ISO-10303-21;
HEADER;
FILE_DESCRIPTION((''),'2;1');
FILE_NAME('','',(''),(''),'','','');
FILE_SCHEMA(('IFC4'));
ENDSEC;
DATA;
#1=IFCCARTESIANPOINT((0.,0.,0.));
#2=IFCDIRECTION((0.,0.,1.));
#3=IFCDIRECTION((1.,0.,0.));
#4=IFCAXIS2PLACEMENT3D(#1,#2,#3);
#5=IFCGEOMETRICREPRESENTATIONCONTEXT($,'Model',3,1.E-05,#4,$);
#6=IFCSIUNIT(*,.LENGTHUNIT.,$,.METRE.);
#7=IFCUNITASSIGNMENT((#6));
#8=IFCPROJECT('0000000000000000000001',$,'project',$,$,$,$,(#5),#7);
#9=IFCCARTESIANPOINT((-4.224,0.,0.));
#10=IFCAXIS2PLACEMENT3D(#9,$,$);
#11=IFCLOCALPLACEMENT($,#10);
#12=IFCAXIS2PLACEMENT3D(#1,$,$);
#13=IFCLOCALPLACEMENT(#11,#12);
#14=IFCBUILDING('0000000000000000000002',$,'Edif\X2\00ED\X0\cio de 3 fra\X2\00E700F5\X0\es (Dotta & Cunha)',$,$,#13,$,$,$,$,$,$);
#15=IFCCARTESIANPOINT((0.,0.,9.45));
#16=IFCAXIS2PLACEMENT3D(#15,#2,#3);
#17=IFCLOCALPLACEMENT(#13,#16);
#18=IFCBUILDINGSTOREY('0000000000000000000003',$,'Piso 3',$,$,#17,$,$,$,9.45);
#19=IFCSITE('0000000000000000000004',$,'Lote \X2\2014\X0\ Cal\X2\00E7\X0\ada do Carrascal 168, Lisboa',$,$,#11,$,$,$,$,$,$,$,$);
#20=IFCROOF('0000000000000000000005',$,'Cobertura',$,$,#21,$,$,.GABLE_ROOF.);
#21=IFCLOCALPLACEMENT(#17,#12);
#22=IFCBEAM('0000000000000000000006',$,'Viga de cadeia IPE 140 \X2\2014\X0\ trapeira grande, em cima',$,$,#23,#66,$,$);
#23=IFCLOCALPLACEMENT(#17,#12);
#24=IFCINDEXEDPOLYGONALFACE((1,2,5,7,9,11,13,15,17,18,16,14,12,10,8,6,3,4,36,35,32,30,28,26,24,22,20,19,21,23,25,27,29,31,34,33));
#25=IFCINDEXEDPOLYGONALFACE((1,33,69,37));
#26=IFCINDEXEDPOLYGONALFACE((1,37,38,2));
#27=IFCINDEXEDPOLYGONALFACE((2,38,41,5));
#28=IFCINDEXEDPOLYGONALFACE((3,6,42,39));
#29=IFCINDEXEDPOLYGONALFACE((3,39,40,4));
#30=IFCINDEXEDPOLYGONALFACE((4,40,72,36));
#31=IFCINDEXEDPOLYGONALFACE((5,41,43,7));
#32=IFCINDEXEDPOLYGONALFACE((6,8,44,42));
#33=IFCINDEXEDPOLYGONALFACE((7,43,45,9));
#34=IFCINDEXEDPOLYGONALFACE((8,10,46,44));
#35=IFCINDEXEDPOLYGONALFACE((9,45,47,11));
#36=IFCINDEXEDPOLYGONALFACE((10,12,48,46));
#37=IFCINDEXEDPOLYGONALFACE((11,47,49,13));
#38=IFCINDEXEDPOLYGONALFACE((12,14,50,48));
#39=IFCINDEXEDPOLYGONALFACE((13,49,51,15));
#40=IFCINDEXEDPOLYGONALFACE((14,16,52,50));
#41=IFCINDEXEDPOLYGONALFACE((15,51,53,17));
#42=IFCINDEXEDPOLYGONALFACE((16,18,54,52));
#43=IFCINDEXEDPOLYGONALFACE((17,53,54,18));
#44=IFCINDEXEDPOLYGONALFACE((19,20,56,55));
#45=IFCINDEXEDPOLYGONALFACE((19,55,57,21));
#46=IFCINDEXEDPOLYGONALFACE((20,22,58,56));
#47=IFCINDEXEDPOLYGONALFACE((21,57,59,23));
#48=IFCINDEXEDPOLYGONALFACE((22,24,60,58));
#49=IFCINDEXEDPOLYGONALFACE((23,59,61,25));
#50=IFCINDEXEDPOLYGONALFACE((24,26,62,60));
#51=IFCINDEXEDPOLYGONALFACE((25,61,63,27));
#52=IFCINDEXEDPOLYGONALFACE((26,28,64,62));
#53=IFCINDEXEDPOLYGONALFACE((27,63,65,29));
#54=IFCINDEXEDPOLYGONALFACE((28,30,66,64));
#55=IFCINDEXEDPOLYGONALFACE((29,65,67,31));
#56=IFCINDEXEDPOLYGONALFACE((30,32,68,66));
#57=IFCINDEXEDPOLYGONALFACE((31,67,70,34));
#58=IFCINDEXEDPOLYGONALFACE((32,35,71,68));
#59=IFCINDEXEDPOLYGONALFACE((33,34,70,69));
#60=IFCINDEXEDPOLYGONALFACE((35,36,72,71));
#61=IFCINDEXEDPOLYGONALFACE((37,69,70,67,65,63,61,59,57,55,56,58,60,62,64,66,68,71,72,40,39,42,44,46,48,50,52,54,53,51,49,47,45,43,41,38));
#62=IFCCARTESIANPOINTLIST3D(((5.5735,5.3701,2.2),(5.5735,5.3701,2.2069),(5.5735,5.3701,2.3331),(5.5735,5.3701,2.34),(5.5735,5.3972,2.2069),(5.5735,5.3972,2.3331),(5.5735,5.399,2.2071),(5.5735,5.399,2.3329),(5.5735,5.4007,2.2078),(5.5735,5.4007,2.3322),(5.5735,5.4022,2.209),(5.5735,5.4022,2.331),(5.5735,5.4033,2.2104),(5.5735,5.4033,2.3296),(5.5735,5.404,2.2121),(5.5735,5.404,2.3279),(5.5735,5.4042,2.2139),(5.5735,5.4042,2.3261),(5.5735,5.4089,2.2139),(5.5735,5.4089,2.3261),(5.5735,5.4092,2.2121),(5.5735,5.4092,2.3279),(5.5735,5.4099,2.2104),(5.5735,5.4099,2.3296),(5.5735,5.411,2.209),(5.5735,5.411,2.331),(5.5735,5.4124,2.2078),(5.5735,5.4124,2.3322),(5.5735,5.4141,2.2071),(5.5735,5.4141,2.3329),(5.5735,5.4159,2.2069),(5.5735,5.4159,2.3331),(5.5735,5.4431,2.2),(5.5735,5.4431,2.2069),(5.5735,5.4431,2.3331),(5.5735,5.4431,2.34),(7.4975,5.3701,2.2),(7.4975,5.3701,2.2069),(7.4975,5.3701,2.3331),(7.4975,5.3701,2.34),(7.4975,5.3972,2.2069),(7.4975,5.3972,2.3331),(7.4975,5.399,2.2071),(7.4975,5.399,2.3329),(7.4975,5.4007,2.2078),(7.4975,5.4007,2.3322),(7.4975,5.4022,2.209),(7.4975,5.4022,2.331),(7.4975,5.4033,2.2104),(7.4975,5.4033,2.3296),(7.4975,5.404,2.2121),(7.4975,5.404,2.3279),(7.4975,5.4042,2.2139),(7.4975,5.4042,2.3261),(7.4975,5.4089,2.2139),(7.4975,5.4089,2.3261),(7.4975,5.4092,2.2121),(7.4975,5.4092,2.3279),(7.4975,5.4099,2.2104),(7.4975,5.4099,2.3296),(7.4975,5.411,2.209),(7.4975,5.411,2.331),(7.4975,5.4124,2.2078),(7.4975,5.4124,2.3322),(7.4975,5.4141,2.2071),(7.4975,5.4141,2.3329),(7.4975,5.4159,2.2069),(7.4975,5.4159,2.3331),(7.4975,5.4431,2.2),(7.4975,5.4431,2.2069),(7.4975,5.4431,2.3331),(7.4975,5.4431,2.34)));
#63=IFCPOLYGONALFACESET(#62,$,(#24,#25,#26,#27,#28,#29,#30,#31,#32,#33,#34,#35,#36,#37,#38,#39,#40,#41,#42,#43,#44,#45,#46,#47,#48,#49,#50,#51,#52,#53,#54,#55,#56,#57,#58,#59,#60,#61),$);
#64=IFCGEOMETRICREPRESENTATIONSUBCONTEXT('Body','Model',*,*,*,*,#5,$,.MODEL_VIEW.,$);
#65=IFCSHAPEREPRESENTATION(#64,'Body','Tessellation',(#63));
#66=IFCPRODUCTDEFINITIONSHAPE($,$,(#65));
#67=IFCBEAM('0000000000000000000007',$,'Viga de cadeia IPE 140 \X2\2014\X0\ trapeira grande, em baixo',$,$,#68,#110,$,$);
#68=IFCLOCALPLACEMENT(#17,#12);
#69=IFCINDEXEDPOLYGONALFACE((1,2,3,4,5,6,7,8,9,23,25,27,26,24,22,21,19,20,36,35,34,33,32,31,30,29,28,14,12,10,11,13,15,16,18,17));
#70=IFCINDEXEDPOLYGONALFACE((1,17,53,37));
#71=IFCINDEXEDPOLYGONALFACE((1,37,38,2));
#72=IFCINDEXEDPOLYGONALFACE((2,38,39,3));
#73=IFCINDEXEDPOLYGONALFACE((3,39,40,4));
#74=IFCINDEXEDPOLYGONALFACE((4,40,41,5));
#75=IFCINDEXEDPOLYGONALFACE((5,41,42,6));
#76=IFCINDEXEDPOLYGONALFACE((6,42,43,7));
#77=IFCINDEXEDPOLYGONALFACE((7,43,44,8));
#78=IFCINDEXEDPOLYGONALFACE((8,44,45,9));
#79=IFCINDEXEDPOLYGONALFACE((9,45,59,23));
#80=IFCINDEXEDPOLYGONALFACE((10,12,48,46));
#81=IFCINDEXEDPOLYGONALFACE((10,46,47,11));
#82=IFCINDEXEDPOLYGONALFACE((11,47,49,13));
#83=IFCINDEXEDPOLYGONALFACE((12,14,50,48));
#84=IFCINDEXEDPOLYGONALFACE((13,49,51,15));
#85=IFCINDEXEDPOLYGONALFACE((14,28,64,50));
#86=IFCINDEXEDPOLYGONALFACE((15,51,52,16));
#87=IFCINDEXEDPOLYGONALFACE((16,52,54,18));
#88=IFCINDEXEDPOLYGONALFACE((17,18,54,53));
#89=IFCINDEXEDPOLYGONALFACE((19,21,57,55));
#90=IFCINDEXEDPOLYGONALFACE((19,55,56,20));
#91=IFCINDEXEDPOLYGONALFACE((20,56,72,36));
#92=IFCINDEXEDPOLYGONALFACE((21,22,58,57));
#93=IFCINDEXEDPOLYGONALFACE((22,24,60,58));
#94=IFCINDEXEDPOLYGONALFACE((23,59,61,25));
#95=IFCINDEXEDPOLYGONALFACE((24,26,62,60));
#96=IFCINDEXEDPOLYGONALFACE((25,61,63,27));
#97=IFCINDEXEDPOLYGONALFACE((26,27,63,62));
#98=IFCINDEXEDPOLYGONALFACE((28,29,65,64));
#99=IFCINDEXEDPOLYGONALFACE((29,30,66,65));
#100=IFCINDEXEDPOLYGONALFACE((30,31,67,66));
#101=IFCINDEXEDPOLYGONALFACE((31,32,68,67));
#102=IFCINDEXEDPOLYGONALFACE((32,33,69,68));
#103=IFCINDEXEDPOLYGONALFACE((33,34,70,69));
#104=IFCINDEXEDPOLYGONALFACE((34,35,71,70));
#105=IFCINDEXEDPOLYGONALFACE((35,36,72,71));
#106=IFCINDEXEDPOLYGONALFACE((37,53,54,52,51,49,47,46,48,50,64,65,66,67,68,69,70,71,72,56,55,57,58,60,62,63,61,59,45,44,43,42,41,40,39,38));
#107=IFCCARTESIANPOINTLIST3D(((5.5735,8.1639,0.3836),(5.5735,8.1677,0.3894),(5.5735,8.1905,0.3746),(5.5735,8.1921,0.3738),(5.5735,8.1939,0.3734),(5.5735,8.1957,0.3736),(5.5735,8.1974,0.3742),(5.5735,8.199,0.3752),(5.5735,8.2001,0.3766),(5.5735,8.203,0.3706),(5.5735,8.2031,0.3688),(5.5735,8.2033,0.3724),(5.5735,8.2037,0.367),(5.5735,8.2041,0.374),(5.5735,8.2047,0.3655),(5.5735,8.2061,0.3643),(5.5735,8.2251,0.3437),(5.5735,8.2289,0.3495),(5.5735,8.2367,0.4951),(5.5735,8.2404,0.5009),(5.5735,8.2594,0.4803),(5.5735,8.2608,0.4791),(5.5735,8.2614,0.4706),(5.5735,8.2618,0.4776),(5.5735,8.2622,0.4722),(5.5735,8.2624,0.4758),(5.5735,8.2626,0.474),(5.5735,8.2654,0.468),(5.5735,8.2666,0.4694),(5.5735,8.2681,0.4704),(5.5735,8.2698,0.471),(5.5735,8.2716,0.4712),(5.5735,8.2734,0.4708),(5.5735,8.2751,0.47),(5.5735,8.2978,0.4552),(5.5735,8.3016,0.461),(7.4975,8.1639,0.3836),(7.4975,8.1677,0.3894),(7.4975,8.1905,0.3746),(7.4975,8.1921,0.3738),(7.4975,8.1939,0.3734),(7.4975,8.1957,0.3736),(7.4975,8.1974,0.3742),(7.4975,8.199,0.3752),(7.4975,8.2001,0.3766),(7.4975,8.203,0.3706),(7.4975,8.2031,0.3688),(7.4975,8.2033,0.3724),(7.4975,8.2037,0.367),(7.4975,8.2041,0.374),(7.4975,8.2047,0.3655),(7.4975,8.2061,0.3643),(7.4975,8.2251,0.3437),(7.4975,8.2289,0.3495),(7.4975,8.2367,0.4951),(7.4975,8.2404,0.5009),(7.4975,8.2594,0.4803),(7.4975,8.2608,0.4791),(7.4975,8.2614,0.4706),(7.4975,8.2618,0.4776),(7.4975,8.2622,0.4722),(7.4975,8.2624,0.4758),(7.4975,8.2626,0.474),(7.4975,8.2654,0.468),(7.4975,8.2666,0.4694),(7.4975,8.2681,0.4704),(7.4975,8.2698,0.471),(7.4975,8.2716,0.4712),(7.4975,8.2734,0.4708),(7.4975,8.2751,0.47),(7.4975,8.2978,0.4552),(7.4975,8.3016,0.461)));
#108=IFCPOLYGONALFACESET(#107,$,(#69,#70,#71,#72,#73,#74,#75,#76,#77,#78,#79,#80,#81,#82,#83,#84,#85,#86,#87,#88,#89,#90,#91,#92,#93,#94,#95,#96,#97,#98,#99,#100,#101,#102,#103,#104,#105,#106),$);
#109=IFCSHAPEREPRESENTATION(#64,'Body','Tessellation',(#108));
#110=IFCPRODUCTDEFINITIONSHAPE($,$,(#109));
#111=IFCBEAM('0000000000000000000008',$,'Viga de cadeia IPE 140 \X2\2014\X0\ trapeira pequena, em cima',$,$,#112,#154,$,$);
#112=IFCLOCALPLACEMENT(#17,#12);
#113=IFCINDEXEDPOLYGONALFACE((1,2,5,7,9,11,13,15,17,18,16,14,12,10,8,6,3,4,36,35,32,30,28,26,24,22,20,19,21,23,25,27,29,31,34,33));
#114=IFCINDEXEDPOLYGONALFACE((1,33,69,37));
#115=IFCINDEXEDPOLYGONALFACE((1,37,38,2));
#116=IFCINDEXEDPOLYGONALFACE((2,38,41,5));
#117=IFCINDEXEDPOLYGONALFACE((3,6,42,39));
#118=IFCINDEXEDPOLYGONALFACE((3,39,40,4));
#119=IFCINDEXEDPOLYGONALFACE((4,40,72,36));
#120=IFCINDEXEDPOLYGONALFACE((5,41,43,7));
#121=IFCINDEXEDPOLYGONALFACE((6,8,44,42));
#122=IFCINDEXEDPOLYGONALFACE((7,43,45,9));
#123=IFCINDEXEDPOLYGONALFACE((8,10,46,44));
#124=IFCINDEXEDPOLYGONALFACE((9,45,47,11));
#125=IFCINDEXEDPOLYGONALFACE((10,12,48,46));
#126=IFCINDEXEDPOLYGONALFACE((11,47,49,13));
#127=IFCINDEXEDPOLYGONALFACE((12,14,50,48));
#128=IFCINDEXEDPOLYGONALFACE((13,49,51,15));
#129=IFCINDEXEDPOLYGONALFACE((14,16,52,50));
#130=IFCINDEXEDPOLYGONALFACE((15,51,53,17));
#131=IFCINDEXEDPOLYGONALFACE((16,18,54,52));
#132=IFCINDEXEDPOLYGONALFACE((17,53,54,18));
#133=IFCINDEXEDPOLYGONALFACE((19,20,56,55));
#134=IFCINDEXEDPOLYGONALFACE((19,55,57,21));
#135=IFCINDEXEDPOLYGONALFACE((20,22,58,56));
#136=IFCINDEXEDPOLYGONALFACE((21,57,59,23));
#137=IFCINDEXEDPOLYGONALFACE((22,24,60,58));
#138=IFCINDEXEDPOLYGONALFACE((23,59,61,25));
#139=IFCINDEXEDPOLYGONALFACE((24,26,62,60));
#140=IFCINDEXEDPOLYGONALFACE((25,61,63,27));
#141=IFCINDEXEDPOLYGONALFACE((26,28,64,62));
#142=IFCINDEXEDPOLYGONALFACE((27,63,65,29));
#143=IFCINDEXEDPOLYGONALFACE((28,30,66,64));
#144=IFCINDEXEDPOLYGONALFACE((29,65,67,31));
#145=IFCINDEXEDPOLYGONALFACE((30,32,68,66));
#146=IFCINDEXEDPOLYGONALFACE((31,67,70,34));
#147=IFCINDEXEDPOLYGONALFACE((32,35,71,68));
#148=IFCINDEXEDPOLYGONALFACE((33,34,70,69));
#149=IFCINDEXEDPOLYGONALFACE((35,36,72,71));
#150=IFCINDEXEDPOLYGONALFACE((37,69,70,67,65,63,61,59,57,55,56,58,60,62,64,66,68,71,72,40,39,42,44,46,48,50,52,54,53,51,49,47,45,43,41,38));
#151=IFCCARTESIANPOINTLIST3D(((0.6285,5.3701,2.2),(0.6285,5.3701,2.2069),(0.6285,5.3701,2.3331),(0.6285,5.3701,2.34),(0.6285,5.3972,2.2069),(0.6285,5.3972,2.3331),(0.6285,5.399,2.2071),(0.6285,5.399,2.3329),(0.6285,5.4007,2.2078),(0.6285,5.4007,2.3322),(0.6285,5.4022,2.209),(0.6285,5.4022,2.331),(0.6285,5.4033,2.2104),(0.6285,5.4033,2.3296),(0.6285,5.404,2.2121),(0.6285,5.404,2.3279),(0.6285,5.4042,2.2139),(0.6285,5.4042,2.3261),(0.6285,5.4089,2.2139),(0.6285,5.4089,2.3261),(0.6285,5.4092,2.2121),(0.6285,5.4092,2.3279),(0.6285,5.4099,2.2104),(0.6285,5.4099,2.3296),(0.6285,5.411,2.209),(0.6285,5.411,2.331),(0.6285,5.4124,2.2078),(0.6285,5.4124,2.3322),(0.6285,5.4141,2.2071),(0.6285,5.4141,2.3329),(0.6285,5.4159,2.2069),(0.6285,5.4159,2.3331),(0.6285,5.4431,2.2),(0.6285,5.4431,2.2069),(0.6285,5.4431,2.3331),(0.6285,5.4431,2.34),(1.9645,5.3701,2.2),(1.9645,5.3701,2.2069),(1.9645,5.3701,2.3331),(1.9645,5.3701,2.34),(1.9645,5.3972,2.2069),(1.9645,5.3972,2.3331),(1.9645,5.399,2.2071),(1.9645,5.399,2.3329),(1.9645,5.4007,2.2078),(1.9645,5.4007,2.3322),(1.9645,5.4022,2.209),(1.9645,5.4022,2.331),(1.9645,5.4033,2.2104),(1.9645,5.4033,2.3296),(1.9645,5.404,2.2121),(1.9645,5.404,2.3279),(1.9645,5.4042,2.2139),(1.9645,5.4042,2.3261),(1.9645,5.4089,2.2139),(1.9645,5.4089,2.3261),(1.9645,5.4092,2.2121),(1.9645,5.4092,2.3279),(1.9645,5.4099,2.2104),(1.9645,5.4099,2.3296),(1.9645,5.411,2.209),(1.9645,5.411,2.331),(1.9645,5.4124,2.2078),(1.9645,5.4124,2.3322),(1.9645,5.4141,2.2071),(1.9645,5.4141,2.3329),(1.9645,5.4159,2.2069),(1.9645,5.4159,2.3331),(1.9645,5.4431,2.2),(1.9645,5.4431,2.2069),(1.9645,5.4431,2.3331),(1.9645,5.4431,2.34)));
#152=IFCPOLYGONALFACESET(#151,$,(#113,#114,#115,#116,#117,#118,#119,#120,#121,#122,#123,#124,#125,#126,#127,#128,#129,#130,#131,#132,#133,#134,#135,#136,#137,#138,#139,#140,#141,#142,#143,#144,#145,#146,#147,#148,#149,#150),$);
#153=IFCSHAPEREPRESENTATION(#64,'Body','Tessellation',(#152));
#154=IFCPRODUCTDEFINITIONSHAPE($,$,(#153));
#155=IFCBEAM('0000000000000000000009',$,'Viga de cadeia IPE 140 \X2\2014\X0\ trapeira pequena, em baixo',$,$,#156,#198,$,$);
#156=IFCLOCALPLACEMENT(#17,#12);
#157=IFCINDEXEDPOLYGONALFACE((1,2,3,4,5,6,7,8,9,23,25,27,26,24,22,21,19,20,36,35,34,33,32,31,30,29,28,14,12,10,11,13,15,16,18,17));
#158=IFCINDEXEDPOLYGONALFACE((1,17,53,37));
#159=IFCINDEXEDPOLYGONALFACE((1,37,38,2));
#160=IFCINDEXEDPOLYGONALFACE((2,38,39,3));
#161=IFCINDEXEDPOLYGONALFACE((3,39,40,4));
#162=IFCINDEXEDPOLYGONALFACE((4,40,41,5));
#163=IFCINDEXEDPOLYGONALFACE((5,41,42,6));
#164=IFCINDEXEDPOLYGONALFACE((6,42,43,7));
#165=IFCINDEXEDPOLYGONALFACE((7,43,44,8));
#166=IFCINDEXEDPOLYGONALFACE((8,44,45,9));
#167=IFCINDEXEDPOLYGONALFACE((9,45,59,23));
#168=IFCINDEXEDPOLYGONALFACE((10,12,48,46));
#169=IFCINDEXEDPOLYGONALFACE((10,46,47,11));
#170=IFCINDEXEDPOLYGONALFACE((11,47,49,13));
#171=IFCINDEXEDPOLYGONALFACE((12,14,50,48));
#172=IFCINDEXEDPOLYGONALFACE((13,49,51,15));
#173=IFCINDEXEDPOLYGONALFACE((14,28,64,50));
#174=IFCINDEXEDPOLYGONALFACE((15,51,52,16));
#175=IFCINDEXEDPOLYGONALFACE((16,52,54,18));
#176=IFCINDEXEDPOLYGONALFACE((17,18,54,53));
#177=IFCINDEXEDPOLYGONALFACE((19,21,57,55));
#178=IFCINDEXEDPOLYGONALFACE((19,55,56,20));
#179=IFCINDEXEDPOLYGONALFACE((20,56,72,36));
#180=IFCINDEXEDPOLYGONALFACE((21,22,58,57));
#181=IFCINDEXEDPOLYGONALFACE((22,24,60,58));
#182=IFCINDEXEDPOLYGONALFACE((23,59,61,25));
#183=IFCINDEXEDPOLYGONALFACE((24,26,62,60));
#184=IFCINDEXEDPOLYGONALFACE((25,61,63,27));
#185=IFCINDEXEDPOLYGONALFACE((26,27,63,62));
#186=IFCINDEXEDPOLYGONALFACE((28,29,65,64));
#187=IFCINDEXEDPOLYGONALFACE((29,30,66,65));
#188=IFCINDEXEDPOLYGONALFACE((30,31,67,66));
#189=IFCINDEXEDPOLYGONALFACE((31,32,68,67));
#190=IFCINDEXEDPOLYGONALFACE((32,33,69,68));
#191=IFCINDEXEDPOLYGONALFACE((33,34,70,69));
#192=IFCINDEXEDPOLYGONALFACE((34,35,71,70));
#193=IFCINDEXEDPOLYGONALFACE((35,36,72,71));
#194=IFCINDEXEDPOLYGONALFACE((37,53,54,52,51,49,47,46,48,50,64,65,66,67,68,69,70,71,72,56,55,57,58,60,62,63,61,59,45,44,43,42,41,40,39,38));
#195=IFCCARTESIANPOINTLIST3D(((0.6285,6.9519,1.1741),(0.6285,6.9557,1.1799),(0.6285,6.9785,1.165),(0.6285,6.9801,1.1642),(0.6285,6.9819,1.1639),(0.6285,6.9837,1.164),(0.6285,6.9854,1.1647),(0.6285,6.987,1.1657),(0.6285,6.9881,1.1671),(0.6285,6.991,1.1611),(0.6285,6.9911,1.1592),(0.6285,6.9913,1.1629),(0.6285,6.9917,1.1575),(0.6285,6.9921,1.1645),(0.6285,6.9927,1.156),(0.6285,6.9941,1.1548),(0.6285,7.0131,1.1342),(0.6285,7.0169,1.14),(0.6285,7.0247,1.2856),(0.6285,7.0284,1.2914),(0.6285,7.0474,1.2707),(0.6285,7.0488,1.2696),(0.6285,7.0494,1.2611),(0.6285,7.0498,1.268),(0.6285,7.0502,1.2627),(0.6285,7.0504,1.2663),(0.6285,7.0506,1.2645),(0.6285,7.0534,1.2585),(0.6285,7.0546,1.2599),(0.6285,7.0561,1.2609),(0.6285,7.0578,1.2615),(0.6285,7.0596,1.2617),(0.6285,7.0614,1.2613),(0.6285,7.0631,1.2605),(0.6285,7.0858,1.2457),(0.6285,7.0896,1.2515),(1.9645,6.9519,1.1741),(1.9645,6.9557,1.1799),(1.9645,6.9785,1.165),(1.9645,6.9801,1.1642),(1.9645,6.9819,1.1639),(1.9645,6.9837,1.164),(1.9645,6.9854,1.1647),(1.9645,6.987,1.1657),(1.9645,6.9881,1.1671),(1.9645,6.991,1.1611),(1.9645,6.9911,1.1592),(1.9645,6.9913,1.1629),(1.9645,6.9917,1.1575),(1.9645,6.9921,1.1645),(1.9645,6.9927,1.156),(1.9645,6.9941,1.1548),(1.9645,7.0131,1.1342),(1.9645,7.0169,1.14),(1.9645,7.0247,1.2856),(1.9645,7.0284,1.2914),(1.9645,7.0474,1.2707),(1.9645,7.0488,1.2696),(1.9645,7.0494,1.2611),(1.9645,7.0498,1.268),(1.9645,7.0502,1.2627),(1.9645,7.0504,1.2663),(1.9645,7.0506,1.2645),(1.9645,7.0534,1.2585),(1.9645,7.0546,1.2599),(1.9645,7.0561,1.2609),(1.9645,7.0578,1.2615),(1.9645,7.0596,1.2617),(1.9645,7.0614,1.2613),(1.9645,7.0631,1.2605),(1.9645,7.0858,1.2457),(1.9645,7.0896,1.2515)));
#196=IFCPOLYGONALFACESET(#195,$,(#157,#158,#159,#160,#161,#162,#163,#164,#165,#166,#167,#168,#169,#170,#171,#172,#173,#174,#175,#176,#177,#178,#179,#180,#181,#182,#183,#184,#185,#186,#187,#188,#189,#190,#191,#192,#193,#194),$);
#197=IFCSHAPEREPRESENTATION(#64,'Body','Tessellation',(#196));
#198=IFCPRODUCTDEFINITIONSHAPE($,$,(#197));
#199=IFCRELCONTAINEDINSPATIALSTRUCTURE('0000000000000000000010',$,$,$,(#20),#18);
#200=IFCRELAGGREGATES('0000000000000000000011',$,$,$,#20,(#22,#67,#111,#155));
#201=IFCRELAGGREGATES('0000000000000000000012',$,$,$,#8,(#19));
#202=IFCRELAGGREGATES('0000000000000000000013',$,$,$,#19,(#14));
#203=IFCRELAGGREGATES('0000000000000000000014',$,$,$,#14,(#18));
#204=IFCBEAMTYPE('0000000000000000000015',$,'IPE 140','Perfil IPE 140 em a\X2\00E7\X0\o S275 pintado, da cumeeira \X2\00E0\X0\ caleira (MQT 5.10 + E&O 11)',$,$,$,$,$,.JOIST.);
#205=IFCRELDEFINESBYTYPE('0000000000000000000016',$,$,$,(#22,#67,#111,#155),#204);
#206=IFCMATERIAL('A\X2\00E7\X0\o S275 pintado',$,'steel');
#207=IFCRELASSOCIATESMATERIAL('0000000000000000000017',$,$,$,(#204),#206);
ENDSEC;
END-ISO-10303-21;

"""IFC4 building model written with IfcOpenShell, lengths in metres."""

from ifc_helpers import new_model, si_unit, frame, origin, origin_with_axes, place, context, subcontext, project, spatial, i_section, extrude, material, type_object, element, aggregate, save


model = new_model("IFC4")

# Units and contexts
model_context = context("Model", 3, precision=1e-05, world=origin_with_axes())
body_context = subcontext(model_context, "Body", "Model", "MODEL_VIEW")
ifc_project = project(units=[si_unit("LENGTHUNIT", "METRE")], contexts=[model_context])

# Site, building, storey
site_placement = place(None, frame((-4.224, 0.0, 0.0)))
site = spatial("IfcSite", under=ifc_project, at=site_placement, Name="Lote — Calçada do Carrascal 168, Lisboa")
building_placement = place(site_placement, origin())
building = spatial("IfcBuilding", under=site, at=building_placement, Name="Edifício de 3 frações (Dotta & Cunha)")
storey_placement = place(building_placement, frame((0.0, 0.0, 9.45), z_axis=(0.0, 0.0, 1.0), x_axis=(1.0, 0.0, 0.0)))
storey = spatial("IfcBuildingStorey", under=building, at=storey_placement, Name="Piso 3", Elevation=9.45)

# Roof, beams
roof_placement = place(storey_placement, frame((0.0, 0.0, -9.45), z_axis=(0.0, 0.0, 1.0), x_axis=(1.0, 0.0, 0.0)))
roof = element("IfcRoof", 1, at=roof_placement, inside=storey, Name="Cobertura", PredefinedType="GABLE_ROOF")
ifc_material_1 = material(Name="Aço S275 pintado", Category="steel")
beam_type_1 = type_object("IfcBeamType", Name="IPE 140", Description="Perfil IPE 140 em aço S275 pintado, da cumeeira à caleira (MQT 5.10 + E&O 11)", PredefinedType="JOIST", material=ifc_material_1)
beam_1_placement = place(roof_placement, frame((5.5735, 5.4066, 11.72), z_axis=(1.0, 0.0, 0.0), x_axis=(0.0, 1.0, 0.0)))
beam_1 = element("IfcBeam", 2, at=beam_1_placement, type_object=beam_type_1, Name="Viga de cadeia IPE 140 — trapeira grande, em cima", context=body_context, shape_type="SweptSolid", body=[
    extrude(i_section(OverallWidth=0.073, OverallDepth=0.14, WebThickness=0.0047, FlangeThickness=0.0069, FilletRadius=0.007), None, (0.0, 0.0, 1.0), 1.924),
])
beam_2_placement = place(roof_placement, frame((5.5735, 8.2328, 9.8723), z_axis=(1.0, 0.0, 0.0), x_axis=(0.0, -0.837595, 0.546292)))
beam_2 = element("IfcBeam", 3, at=beam_2_placement, type_object=beam_type_1, Name="Viga de cadeia IPE 140 — trapeira grande, em baixo", context=body_context, shape_type="SweptSolid", body=[
    extrude(i_section(OverallWidth=0.073, OverallDepth=0.14, WebThickness=0.0047, FlangeThickness=0.0069, FilletRadius=0.007), None, (0.0, 0.0, 1.0), 1.924),
])
beam_3_placement = place(roof_placement, frame((0.6285, 5.4066, 11.72), z_axis=(1.0, 0.0, 0.0), x_axis=(0.0, 1.0, 0.0)))
beam_3 = element("IfcBeam", 4, at=beam_3_placement, type_object=beam_type_1, Name="Viga de cadeia IPE 140 — trapeira pequena, em cima", context=body_context, shape_type="SweptSolid", body=[
    extrude(i_section(OverallWidth=0.073, OverallDepth=0.14, WebThickness=0.0047, FlangeThickness=0.0069, FilletRadius=0.007), None, (0.0, 0.0, 1.0), 1.336),
])
beam_4_placement = place(roof_placement, frame((0.6285, 7.0208, 10.6628), z_axis=(1.0, 0.0, 0.0), x_axis=(0.0, -0.837595, 0.546292)))
beam_4 = element("IfcBeam", 5, at=beam_4_placement, type_object=beam_type_1, Name="Viga de cadeia IPE 140 — trapeira pequena, em baixo", context=body_context, shape_type="SweptSolid", body=[
    extrude(i_section(OverallWidth=0.073, OverallDepth=0.14, WebThickness=0.0047, FlangeThickness=0.0069, FilletRadius=0.007), None, (0.0, 0.0, 1.0), 1.336),
])

aggregate(roof, [beam_1, beam_2, beam_3, beam_4])

save(model, "model.ifc")
